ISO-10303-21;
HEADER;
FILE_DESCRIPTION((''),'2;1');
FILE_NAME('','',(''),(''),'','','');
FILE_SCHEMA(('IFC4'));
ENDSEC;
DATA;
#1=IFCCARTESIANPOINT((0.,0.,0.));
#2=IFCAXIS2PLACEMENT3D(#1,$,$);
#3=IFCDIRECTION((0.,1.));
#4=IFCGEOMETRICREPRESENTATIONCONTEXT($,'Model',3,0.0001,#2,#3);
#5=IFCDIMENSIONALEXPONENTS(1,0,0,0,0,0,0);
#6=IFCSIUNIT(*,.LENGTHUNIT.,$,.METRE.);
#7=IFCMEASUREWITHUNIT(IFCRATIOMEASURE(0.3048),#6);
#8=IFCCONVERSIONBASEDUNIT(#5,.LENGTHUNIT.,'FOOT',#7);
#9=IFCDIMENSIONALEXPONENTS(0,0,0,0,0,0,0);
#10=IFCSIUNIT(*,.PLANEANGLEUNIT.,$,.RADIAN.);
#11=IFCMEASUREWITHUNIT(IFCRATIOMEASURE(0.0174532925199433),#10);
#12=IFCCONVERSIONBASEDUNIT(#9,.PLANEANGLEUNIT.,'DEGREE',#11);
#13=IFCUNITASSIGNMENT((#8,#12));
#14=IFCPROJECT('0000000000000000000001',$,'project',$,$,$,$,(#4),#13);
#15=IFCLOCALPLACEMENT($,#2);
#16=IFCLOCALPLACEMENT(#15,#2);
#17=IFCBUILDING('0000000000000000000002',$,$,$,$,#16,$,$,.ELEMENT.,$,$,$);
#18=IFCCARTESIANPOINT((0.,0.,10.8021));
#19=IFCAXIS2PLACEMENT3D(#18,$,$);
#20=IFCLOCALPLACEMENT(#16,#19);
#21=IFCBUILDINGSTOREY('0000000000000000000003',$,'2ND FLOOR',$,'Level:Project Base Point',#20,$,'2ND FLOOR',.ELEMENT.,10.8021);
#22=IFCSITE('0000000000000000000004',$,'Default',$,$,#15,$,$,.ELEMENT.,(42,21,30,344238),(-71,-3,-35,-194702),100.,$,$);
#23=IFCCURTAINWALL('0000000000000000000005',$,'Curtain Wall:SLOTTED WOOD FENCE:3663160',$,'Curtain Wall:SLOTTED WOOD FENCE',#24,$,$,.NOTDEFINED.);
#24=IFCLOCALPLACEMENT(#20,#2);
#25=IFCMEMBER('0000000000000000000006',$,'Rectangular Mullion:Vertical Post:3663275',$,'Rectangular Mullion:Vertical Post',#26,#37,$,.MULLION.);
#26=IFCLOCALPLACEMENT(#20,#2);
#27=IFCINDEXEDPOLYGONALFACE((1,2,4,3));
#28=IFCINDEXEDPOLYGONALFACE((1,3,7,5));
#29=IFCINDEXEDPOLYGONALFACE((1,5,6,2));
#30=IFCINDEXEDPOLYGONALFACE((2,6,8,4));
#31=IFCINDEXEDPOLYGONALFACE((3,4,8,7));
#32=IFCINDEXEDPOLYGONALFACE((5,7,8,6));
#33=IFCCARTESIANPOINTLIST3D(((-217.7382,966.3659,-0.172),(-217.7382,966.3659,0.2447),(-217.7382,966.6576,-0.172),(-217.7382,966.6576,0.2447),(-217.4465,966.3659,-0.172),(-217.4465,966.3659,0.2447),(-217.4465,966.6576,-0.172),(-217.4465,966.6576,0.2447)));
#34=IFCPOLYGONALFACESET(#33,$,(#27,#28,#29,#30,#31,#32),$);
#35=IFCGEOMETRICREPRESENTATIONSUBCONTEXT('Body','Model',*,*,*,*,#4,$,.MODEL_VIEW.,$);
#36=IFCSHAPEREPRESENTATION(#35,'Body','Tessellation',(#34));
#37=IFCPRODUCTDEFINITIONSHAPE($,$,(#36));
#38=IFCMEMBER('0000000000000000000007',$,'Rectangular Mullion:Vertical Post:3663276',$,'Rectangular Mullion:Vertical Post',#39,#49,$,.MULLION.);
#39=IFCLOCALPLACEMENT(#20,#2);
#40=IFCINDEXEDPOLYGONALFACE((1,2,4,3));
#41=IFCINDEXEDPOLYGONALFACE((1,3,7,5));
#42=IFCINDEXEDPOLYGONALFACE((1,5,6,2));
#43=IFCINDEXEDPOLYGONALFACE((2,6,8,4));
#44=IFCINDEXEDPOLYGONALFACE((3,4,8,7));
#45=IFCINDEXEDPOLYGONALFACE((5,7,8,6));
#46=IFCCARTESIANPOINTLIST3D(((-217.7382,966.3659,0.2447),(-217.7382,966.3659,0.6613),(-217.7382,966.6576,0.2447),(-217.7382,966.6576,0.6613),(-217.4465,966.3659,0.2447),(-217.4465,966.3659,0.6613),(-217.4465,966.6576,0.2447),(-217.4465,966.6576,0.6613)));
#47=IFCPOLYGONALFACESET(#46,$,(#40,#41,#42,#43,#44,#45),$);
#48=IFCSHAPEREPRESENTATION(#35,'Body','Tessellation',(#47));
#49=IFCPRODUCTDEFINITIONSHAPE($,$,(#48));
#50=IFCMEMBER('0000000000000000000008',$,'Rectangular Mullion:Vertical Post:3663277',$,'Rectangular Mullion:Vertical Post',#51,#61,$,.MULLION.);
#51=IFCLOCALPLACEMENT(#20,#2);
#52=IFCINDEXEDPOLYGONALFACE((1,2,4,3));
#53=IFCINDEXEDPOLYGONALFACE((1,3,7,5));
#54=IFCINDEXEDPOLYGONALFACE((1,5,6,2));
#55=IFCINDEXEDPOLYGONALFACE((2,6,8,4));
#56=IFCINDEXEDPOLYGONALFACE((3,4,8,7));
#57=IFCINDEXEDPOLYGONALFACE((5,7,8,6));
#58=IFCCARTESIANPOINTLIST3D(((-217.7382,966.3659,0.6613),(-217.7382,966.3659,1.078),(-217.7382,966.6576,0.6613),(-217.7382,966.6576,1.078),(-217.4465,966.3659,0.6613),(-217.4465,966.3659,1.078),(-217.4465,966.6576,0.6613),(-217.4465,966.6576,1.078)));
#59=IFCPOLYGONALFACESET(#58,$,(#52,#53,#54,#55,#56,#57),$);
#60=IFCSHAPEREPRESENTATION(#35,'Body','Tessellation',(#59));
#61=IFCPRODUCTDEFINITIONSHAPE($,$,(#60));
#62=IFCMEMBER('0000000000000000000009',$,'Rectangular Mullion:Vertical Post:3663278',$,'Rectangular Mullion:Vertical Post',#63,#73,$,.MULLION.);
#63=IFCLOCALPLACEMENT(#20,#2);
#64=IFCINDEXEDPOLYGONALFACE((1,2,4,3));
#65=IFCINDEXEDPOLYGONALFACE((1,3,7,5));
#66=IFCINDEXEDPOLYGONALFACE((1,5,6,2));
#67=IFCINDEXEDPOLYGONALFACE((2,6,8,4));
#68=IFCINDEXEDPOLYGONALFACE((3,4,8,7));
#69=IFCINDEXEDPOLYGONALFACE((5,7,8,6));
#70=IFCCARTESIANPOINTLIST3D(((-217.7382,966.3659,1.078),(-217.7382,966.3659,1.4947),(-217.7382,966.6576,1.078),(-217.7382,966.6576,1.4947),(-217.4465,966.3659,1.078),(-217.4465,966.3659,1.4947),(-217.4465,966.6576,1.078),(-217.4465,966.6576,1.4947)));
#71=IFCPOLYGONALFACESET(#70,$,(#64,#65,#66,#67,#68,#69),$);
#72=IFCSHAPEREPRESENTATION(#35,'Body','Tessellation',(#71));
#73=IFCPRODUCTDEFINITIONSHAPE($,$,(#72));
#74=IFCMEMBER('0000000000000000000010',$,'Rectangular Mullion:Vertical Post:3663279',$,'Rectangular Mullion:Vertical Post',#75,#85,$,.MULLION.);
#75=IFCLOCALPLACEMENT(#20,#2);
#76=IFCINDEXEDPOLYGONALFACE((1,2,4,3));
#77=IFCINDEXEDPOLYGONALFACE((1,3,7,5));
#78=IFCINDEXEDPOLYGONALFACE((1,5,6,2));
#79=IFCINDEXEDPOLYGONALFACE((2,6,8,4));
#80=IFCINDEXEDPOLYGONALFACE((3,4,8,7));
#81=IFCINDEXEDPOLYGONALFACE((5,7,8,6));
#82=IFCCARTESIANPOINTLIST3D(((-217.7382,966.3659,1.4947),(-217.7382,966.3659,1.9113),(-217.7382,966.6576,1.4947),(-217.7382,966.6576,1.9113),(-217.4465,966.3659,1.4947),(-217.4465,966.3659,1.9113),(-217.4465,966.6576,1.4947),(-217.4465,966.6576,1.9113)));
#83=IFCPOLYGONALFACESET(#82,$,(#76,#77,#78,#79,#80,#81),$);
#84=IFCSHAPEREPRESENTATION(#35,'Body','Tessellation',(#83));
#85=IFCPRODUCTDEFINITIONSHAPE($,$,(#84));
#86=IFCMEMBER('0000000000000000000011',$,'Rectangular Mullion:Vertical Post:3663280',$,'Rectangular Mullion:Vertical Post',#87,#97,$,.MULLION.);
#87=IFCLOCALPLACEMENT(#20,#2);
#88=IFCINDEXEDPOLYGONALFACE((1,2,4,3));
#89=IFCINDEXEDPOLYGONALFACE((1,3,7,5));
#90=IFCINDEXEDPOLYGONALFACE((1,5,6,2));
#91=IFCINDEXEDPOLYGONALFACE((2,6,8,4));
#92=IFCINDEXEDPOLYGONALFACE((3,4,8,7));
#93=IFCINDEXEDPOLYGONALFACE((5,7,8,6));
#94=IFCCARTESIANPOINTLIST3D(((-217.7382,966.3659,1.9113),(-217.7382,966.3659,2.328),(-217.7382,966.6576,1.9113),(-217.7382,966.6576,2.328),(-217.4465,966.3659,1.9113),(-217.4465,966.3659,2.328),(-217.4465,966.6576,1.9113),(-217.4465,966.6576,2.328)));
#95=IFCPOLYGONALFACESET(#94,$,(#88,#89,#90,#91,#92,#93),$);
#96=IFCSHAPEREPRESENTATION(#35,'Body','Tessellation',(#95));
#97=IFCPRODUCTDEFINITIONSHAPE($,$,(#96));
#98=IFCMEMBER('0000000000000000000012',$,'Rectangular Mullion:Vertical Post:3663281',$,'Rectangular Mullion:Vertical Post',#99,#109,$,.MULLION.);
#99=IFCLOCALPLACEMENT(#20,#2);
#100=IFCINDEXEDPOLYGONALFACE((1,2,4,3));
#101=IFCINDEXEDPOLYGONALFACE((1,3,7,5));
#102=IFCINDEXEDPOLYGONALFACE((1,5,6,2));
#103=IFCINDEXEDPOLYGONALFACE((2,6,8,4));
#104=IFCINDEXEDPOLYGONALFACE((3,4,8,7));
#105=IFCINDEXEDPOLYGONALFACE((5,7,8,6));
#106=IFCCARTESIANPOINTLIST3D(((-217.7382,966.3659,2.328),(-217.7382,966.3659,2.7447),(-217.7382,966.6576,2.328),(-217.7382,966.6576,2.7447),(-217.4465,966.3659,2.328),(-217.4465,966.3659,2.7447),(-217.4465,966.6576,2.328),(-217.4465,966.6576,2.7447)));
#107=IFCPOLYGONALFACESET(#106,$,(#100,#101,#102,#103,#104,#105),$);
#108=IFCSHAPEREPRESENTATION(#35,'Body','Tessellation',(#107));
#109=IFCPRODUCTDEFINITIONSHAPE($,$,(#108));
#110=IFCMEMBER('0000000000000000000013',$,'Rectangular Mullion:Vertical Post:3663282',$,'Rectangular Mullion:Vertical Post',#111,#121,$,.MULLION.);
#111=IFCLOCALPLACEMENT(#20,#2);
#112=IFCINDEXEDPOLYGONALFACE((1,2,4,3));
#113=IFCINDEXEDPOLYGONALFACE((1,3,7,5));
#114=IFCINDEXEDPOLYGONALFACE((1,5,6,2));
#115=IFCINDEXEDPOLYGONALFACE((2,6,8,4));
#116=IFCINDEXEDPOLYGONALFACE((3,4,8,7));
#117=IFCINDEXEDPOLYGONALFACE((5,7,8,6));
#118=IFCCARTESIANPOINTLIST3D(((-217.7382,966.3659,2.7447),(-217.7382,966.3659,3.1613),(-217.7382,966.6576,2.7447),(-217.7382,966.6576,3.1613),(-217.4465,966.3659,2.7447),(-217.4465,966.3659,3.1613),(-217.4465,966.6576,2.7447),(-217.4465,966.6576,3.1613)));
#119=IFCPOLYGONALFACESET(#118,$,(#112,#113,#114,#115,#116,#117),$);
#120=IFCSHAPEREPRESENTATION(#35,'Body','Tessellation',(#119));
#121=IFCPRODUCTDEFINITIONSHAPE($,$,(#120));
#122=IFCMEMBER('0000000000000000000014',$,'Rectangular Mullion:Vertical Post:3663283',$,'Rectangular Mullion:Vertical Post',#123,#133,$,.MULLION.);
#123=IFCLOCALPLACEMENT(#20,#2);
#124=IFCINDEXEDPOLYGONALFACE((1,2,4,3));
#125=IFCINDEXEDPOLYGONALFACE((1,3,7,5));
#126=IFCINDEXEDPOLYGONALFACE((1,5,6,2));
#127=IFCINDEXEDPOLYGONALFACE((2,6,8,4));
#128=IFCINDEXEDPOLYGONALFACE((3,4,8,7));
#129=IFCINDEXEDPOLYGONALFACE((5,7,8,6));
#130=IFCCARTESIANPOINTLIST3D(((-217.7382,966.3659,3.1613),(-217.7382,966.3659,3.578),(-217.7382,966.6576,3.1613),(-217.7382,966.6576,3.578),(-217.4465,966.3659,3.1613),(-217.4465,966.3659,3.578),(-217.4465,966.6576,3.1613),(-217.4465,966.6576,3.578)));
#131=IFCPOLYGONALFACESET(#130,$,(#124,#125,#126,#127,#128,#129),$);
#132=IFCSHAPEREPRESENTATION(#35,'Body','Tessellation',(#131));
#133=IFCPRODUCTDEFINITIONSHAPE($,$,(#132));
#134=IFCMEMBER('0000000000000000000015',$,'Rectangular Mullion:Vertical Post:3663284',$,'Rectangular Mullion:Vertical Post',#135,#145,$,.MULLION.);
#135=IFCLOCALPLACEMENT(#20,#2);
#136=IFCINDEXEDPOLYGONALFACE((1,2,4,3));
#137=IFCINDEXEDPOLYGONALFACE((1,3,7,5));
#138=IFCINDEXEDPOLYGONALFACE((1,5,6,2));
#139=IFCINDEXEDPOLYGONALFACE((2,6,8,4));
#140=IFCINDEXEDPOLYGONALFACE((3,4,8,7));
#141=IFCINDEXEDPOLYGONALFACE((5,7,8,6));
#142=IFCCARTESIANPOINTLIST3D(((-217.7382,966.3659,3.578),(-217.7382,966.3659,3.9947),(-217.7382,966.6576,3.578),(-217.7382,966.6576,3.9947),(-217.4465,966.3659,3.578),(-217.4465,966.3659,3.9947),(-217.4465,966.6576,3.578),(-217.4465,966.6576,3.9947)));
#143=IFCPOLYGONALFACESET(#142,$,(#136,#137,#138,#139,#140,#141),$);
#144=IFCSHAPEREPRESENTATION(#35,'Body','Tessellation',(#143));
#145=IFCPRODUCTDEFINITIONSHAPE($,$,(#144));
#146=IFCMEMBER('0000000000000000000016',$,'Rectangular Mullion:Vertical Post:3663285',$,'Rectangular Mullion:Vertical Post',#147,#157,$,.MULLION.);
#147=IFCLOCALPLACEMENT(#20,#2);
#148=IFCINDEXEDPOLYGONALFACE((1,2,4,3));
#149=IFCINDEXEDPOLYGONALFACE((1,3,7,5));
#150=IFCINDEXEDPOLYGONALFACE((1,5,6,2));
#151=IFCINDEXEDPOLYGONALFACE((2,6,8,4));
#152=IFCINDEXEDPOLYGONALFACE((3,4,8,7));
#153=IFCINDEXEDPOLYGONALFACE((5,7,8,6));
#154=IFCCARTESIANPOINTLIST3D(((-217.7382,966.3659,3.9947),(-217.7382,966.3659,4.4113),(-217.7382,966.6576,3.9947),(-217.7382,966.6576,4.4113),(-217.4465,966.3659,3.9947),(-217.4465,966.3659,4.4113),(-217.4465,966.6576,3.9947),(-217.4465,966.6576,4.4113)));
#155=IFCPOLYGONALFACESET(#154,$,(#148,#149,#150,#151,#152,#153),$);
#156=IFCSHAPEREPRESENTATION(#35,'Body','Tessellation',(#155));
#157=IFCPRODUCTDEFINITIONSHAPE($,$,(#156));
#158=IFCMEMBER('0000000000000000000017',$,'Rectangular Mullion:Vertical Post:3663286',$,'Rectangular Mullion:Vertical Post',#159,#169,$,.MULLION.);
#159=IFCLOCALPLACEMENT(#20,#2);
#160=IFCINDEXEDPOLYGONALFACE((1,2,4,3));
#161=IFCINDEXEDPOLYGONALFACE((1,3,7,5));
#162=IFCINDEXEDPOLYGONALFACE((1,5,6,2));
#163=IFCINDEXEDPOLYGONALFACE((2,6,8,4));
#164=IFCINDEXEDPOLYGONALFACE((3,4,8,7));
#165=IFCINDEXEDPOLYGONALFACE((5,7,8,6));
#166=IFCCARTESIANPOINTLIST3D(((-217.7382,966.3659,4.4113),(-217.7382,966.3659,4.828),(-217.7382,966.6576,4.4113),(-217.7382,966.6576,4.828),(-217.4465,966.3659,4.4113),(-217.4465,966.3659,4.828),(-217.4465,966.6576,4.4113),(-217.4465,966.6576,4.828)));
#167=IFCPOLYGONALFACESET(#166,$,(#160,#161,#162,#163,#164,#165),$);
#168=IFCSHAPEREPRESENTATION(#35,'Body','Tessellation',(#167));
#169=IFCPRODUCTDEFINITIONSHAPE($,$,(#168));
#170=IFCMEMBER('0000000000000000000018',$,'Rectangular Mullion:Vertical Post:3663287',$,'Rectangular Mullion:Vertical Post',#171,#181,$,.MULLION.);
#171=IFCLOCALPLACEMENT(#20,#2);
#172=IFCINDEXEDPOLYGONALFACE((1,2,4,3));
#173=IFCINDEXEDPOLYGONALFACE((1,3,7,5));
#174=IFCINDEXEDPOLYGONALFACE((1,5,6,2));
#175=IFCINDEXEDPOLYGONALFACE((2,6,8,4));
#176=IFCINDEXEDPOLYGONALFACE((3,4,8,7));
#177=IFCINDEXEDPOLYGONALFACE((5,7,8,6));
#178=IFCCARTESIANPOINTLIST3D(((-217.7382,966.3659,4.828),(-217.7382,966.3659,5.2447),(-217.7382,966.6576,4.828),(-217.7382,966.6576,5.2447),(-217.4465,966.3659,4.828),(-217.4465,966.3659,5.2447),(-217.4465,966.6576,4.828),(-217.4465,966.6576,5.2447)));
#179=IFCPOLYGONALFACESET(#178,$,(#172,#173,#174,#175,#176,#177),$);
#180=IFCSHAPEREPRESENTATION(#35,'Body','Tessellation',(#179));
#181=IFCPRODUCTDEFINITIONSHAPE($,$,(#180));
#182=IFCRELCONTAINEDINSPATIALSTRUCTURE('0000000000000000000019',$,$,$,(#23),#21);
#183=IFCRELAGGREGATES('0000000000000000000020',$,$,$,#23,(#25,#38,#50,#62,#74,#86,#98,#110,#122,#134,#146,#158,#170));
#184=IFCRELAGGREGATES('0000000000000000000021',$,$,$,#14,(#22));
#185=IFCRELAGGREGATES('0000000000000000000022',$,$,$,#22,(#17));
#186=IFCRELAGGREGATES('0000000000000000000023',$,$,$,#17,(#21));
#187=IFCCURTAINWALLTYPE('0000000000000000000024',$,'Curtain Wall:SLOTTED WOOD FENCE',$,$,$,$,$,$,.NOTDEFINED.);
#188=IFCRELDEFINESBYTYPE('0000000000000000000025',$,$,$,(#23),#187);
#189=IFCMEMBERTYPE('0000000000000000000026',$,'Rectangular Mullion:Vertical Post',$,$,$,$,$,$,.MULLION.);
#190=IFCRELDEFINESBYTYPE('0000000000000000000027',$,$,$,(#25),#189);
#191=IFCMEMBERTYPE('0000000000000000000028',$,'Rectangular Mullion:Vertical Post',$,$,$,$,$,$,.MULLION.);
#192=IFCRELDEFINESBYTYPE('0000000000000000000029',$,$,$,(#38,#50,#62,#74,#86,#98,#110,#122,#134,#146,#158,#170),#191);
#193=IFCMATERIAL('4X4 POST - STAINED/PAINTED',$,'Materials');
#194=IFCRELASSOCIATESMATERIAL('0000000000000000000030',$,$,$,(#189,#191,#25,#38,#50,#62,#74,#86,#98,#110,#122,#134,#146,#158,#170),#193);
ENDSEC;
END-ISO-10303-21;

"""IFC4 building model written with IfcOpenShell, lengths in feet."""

from ifc_helpers import new_model, entity, si_unit, converted_unit, direction, frame, origin, origin_2d_with_axis, place, context, subcontext, project, spatial, rectangle, extrude, source, transform, mapped, material, material_profile, profile_set, profile_usage, type_object, type_shapes, element, aggregate, save


model = new_model("IFC4")

# Units and contexts
model_context = context("Model", 3, precision=0.0001, world=origin(), true_north=direction((0.0, 1.0)))
body_context = subcontext(model_context, "Body", "Model", "MODEL_VIEW")
ifc_project = project(units=[converted_unit("LENGTHUNIT", "FOOT", entity("IfcRatioMeasure", 0.3048), si_unit("LENGTHUNIT", "METRE"), dimensions=[1, 0, 0, 0, 0, 0, 0]), converted_unit("PLANEANGLEUNIT", "DEGREE", entity("IfcRatioMeasure", 0.0174532925199433), si_unit("PLANEANGLEUNIT", "RADIAN"), dimensions=[0, 0, 0, 0, 0, 0, 0])], contexts=[model_context])

# Site, building, storey
site_placement = place(None, origin())
site = spatial("IfcSite", under=ifc_project, at=site_placement, Name="Default", CompositionType="ELEMENT", RefLatitude=(42, 21, 30, 344238), RefLongitude=(-71, -3, -35, -194702), RefElevation=100.0)
building_placement = place(site_placement, origin())
building = spatial("IfcBuilding", under=site, at=building_placement, CompositionType="ELEMENT")
storey_placement = place(building_placement, frame((0.0, 0.0, 10.8021)))
storey = spatial("IfcBuildingStorey", under=building, at=storey_placement, Name="2ND FLOOR", ObjectType="Level:Project Base Point", LongName="2ND FLOOR", CompositionType="ELEMENT", Elevation=10.8021)

# Curtain wall, members
curtain_wall_type = type_object("IfcCurtainWallType", Name="Curtain Wall:SLOTTED WOOD FENCE", PredefinedType="NOTDEFINED")
curtain_wall_placement = place(storey_placement, frame((0.0, 0.0, -10.8021)))
curtain_wall = element("IfcCurtainWall", 1, at=curtain_wall_placement, inside=storey, type_object=curtain_wall_type, Name="Curtain Wall:SLOTTED WOOD FENCE:3663160", ObjectType="Curtain Wall:SLOTTED WOOD FENCE", PredefinedType="NOTDEFINED")
ifc_material_1 = material(Name="4X4 POST - STAINED/PAINTED", Category="Materials")
ifc_material_profile = material_profile(ifc_material_1, rectangle(XDim=0.2917, YDim=0.2917, at=origin_2d_with_axis()), Name="Vertical Post")
ifc_profile_set = profile_set([ifc_material_profile], Name="Vertical Post")
ifc_profile_usage_1 = profile_usage(ifc_profile_set)
member_type_1 = type_object("IfcMemberType", Name="Rectangular Mullion:Vertical Post", PredefinedType="MULLION", material=ifc_profile_set)
shared_shape_1 = source(origin(), body_context, "Body", "SweptSolid", [
    extrude(rectangle(XDim=0.2917, YDim=0.2917, at=origin_2d_with_axis()), frame((0.0, -0.2083, -0.4167), z_axis=(0.0, 0.0, 1.0), x_axis=(0.0, -1.0, 0.0)), (0.0, 0.0, 1.0), 0.4167),
])
type_shapes(member_type_1, [shared_shape_1])
member_1_placement = place(storey_placement, frame((-217.8007, 966.5118, -0.172), z_axis=(0.0, 0.0, -1.0), x_axis=(0.0, -1.0, 0.0)))
member_1 = element("IfcMember", 2, at=member_1_placement, type_object=member_type_1, material=ifc_profile_usage_1, Name="Rectangular Mullion:Vertical Post:3663275", ObjectType="Rectangular Mullion:Vertical Post", PredefinedType="MULLION", context=body_context, shape_type="MappedRepresentation", body=[
    mapped(shared_shape_1, transform((0.0, 0.0, 0.0), scale=1.0)),
])
ifc_profile_usage_2 = profile_usage(ifc_profile_set)
member_type_2 = type_object("IfcMemberType", Name="Rectangular Mullion:Vertical Post", PredefinedType="MULLION", material=ifc_profile_set)
shared_shape_2 = source(origin(), body_context, "Body", "SweptSolid", [
    extrude(rectangle(XDim=0.2917, YDim=0.2917, at=origin_2d_with_axis()), frame((0.0, -0.2083, -0.4167), z_axis=(0.0, 0.0, 1.0), x_axis=(0.0, -1.0, 0.0)), (0.0, 0.0, 1.0), 0.4167),
])
type_shapes(member_type_2, [shared_shape_2])
member_2_placement = place(storey_placement, frame((-217.8007, 966.5118, 0.2447), z_axis=(0.0, 0.0, -1.0), x_axis=(0.0, -1.0, 0.0)))
member_2 = element("IfcMember", 3, at=member_2_placement, type_object=member_type_2, material=ifc_profile_usage_2, Name="Rectangular Mullion:Vertical Post:3663276", ObjectType="Rectangular Mullion:Vertical Post", PredefinedType="MULLION", context=body_context, shape_type="MappedRepresentation", body=[
    mapped(shared_shape_2, transform((0.0, 0.0, 0.0), scale=1.0)),
])
ifc_profile_usage_3 = profile_usage(ifc_profile_set)
member_3_placement = place(storey_placement, frame((-217.8007, 966.5118, 0.6613), z_axis=(0.0, 0.0, -1.0), x_axis=(0.0, -1.0, 0.0)))
member_3 = element("IfcMember", 4, at=member_3_placement, type_object=member_type_2, material=ifc_profile_usage_3, Name="Rectangular Mullion:Vertical Post:3663277", ObjectType="Rectangular Mullion:Vertical Post", PredefinedType="MULLION", context=body_context, shape_type="MappedRepresentation", body=[
    mapped(shared_shape_2, transform((0.0, 0.0, 0.0), scale=1.0)),
])
ifc_profile_usage_4 = profile_usage(ifc_profile_set)
member_4_placement = place(storey_placement, frame((-217.8007, 966.5118, 1.078), z_axis=(0.0, 0.0, -1.0), x_axis=(0.0, -1.0, 0.0)))
member_4 = element("IfcMember", 5, at=member_4_placement, type_object=member_type_2, material=ifc_profile_usage_4, Name="Rectangular Mullion:Vertical Post:3663278", ObjectType="Rectangular Mullion:Vertical Post", PredefinedType="MULLION", context=body_context, shape_type="MappedRepresentation", body=[
    mapped(shared_shape_2, transform((0.0, 0.0, 0.0), scale=1.0)),
])
ifc_profile_usage_5 = profile_usage(ifc_profile_set)
member_5_placement = place(storey_placement, frame((-217.8007, 966.5118, 1.4947), z_axis=(0.0, 0.0, -1.0), x_axis=(0.0, -1.0, 0.0)))
member_5 = element("IfcMember", 6, at=member_5_placement, type_object=member_type_2, material=ifc_profile_usage_5, Name="Rectangular Mullion:Vertical Post:3663279", ObjectType="Rectangular Mullion:Vertical Post", PredefinedType="MULLION", context=body_context, shape_type="MappedRepresentation", body=[
    mapped(shared_shape_2, transform((0.0, 0.0, 0.0), scale=1.0)),
])
ifc_profile_usage_6 = profile_usage(ifc_profile_set)
member_6_placement = place(storey_placement, frame((-217.8007, 966.5118, 1.9113), z_axis=(0.0, 0.0, -1.0), x_axis=(0.0, -1.0, 0.0)))
member_6 = element("IfcMember", 7, at=member_6_placement, type_object=member_type_2, material=ifc_profile_usage_6, Name="Rectangular Mullion:Vertical Post:3663280", ObjectType="Rectangular Mullion:Vertical Post", PredefinedType="MULLION", context=body_context, shape_type="MappedRepresentation", body=[
    mapped(shared_shape_2, transform((0.0, 0.0, 0.0), scale=1.0)),
])
ifc_profile_usage_7 = profile_usage(ifc_profile_set)
member_7_placement = place(storey_placement, frame((-217.8007, 966.5118, 2.328), z_axis=(0.0, 0.0, -1.0), x_axis=(0.0, -1.0, 0.0)))
member_7 = element("IfcMember", 8, at=member_7_placement, type_object=member_type_2, material=ifc_profile_usage_7, Name="Rectangular Mullion:Vertical Post:3663281", ObjectType="Rectangular Mullion:Vertical Post", PredefinedType="MULLION", context=body_context, shape_type="MappedRepresentation", body=[
    mapped(shared_shape_2, transform((0.0, 0.0, 0.0), scale=1.0)),
])
ifc_profile_usage_8 = profile_usage(ifc_profile_set)
member_8_placement = place(storey_placement, frame((-217.8007, 966.5118, 2.7447), z_axis=(0.0, 0.0, -1.0), x_axis=(0.0, -1.0, 0.0)))
member_8 = element("IfcMember", 9, at=member_8_placement, type_object=member_type_2, material=ifc_profile_usage_8, Name="Rectangular Mullion:Vertical Post:3663282", ObjectType="Rectangular Mullion:Vertical Post", PredefinedType="MULLION", context=body_context, shape_type="MappedRepresentation", body=[
    mapped(shared_shape_2, transform((0.0, 0.0, 0.0), scale=1.0)),
])
ifc_profile_usage_9 = profile_usage(ifc_profile_set)
member_9_placement = place(storey_placement, frame((-217.8007, 966.5118, 3.1613), z_axis=(0.0, 0.0, -1.0), x_axis=(0.0, -1.0, 0.0)))
member_9 = element("IfcMember", 10, at=member_9_placement, type_object=member_type_2, material=ifc_profile_usage_9, Name="Rectangular Mullion:Vertical Post:3663283", ObjectType="Rectangular Mullion:Vertical Post", PredefinedType="MULLION", context=body_context, shape_type="MappedRepresentation", body=[
    mapped(shared_shape_2, transform((0.0, 0.0, 0.0), scale=1.0)),
])
ifc_profile_usage_10 = profile_usage(ifc_profile_set)
member_10_placement = place(storey_placement, frame((-217.8007, 966.5118, 3.578), z_axis=(0.0, 0.0, -1.0), x_axis=(0.0, -1.0, 0.0)))
member_10 = element("IfcMember", 11, at=member_10_placement, type_object=member_type_2, material=ifc_profile_usage_10, Name="Rectangular Mullion:Vertical Post:3663284", ObjectType="Rectangular Mullion:Vertical Post", PredefinedType="MULLION", context=body_context, shape_type="MappedRepresentation", body=[
    mapped(shared_shape_2, transform((0.0, 0.0, 0.0), scale=1.0)),
])
ifc_profile_usage_11 = profile_usage(ifc_profile_set)
member_11_placement = place(storey_placement, frame((-217.8007, 966.5118, 3.9947), z_axis=(0.0, 0.0, -1.0), x_axis=(0.0, -1.0, 0.0)))
member_11 = element("IfcMember", 12, at=member_11_placement, type_object=member_type_2, material=ifc_profile_usage_11, Name="Rectangular Mullion:Vertical Post:3663285", ObjectType="Rectangular Mullion:Vertical Post", PredefinedType="MULLION", context=body_context, shape_type="MappedRepresentation", body=[
    mapped(shared_shape_2, transform((0.0, 0.0, 0.0), scale=1.0)),
])
ifc_profile_usage_12 = profile_usage(ifc_profile_set)
member_12_placement = place(storey_placement, frame((-217.8007, 966.5118, 4.4113), z_axis=(0.0, 0.0, -1.0), x_axis=(0.0, -1.0, 0.0)))
member_12 = element("IfcMember", 13, at=member_12_placement, type_object=member_type_2, material=ifc_profile_usage_12, Name="Rectangular Mullion:Vertical Post:3663286", ObjectType="Rectangular Mullion:Vertical Post", PredefinedType="MULLION", context=body_context, shape_type="MappedRepresentation", body=[
    mapped(shared_shape_2, transform((0.0, 0.0, 0.0), scale=1.0)),
])
ifc_profile_usage_13 = profile_usage(ifc_profile_set)
member_13_placement = place(storey_placement, frame((-217.8007, 966.5118, 4.828), z_axis=(0.0, 0.0, -1.0), x_axis=(0.0, -1.0, 0.0)))
member_13 = element("IfcMember", 14, at=member_13_placement, type_object=member_type_2, material=ifc_profile_usage_13, Name="Rectangular Mullion:Vertical Post:3663287", ObjectType="Rectangular Mullion:Vertical Post", PredefinedType="MULLION", context=body_context, shape_type="MappedRepresentation", body=[
    mapped(shared_shape_2, transform((0.0, 0.0, 0.0), scale=1.0)),
])
aggregate(curtain_wall, [member_1, member_2, member_3, member_4, member_5, member_6, member_7, member_8, member_9, member_10, member_11, member_12, member_13])

save(model, "model.ifc")
